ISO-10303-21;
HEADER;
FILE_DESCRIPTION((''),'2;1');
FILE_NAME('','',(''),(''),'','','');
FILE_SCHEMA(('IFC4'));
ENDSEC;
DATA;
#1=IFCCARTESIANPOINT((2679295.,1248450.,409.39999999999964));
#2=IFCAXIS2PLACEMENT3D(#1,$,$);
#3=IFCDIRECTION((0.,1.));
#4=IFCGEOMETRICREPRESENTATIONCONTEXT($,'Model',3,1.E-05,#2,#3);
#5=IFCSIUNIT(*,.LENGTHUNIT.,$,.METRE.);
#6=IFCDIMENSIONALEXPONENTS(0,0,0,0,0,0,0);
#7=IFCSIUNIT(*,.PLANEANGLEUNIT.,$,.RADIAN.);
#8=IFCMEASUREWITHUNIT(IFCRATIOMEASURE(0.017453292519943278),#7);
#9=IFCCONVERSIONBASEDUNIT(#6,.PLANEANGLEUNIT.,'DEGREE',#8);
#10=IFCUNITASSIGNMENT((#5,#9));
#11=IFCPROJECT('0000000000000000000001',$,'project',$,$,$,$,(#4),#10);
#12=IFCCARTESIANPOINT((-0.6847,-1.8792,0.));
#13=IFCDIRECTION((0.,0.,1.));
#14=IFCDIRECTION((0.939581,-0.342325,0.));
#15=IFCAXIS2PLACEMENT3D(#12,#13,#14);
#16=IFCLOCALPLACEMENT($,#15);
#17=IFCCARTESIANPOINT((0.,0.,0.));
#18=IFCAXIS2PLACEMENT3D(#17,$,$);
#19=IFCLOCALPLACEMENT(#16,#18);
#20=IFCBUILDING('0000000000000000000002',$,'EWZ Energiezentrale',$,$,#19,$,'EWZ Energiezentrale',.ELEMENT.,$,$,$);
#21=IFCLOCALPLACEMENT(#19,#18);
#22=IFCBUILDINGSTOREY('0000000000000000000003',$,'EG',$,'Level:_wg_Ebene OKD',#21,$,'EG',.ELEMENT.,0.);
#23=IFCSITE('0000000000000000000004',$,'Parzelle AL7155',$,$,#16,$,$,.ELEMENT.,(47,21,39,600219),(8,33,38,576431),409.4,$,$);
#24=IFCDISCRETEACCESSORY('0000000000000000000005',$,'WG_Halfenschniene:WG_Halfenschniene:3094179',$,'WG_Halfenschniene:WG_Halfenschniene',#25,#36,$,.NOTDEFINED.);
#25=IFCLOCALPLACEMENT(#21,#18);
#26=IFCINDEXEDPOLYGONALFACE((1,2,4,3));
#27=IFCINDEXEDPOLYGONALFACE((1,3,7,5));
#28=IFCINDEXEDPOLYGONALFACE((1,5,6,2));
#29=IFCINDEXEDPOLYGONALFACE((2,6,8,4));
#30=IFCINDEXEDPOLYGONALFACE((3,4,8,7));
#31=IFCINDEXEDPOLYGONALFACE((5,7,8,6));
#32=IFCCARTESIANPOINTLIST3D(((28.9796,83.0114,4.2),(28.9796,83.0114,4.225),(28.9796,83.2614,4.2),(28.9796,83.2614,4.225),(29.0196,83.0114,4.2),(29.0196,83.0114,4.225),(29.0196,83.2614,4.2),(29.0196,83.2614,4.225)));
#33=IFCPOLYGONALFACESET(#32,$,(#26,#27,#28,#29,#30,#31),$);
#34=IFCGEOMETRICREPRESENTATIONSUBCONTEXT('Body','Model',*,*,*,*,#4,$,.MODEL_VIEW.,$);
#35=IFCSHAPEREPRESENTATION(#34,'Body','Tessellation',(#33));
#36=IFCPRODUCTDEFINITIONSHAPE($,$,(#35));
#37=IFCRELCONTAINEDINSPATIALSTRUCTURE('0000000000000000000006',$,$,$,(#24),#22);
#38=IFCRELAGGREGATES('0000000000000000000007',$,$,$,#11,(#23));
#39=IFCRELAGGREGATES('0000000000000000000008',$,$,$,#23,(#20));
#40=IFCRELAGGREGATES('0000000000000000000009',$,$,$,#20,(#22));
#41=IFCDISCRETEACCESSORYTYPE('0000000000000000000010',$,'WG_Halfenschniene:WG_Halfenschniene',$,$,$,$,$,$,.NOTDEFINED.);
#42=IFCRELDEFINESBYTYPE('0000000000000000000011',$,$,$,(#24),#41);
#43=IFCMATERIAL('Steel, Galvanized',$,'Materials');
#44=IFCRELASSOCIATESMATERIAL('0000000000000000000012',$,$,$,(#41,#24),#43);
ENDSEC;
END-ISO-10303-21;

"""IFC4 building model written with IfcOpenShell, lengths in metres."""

from ifc_helpers import new_model, entity, si_unit, converted_unit, direction, frame, origin, place, context, subcontext, project, spatial, indexed_curve, outline, extrude, source, transform, mapped, material, type_object, element, save


model = new_model("IFC4")

# Units and contexts
model_context = context("Model", 3, precision=1e-05, world=frame((2679295.0, 1248450.0, 409.39999999999964)), true_north=direction((0.0, 1.0)))
body_context = subcontext(model_context, "Body", "Model", "MODEL_VIEW")
ifc_project = project(units=[si_unit("LENGTHUNIT", "METRE"), converted_unit("PLANEANGLEUNIT", "DEGREE", entity("IfcRatioMeasure", 0.017453292519943278), si_unit("PLANEANGLEUNIT", "RADIAN"), dimensions=[0, 0, 0, 0, 0, 0, 0])], contexts=[model_context])

# Site, building, storey
site_placement = place(None, frame((-0.6847, -1.8792, 0.0), z_axis=(0.0, 0.0, 1.0), x_axis=(0.939581, -0.342325, 0.0)))
site = spatial("IfcSite", under=ifc_project, at=site_placement, Name="Parzelle AL7155", CompositionType="ELEMENT", RefLatitude=(47, 21, 39, 600219), RefLongitude=(8, 33, 38, 576431), RefElevation=409.4)
building_placement = place(site_placement, origin())
building = spatial("IfcBuilding", under=site, at=building_placement, Name="EWZ Energiezentrale", LongName="EWZ Energiezentrale", CompositionType="ELEMENT")
storey_placement = place(building_placement, origin())
storey = spatial("IfcBuildingStorey", under=building, at=storey_placement, Name="EG", ObjectType="Level:_wg_Ebene OKD", LongName="EG", CompositionType="ELEMENT", Elevation=0.0)

# Discrete accessory
ifc_material = material(Name="Steel, Galvanized", Category="Materials")
discrete_accessory_type = type_object("IfcDiscreteAccessoryType", Name="WG_Halfenschniene:WG_Halfenschniene", PredefinedType="NOTDEFINED", material=ifc_material)
shared_shape = source(origin(), body_context, "Body", "SweptSolid", [
    extrude(outline(indexed_curve([(-0.125, -0.02), (0.125, -0.02), (0.125, 0.02), (-0.125, 0.02), (-0.125, -0.02)], self_intersect=False)), frame((0.125, 0.0, -0.0125)), (0.0, 0.0, 1.0), 0.025),
])
for number, where, z_axis, x_axis, name in (
    (1, (28.9996, 83.0114, 4.2125), (0.0, 0.0, -1.0), (0.0, 1.0, 0.0), "WG_Halfenschniene:WG_Halfenschniene:3094179"),
):
    element("IfcDiscreteAccessory", number, at=place(storey_placement, frame(where, z_axis=z_axis, x_axis=x_axis)), inside=storey, type_object=discrete_accessory_type, material=ifc_material, Name=name, ObjectType="WG_Halfenschniene:WG_Halfenschniene", PredefinedType="NOTDEFINED", context=body_context, shape_type="MappedRepresentation", body=[
        mapped(shared_shape, transform((0.0, 0.0, 0.0), scale=1.0)),
    ])

save(model, "model.ifc")
